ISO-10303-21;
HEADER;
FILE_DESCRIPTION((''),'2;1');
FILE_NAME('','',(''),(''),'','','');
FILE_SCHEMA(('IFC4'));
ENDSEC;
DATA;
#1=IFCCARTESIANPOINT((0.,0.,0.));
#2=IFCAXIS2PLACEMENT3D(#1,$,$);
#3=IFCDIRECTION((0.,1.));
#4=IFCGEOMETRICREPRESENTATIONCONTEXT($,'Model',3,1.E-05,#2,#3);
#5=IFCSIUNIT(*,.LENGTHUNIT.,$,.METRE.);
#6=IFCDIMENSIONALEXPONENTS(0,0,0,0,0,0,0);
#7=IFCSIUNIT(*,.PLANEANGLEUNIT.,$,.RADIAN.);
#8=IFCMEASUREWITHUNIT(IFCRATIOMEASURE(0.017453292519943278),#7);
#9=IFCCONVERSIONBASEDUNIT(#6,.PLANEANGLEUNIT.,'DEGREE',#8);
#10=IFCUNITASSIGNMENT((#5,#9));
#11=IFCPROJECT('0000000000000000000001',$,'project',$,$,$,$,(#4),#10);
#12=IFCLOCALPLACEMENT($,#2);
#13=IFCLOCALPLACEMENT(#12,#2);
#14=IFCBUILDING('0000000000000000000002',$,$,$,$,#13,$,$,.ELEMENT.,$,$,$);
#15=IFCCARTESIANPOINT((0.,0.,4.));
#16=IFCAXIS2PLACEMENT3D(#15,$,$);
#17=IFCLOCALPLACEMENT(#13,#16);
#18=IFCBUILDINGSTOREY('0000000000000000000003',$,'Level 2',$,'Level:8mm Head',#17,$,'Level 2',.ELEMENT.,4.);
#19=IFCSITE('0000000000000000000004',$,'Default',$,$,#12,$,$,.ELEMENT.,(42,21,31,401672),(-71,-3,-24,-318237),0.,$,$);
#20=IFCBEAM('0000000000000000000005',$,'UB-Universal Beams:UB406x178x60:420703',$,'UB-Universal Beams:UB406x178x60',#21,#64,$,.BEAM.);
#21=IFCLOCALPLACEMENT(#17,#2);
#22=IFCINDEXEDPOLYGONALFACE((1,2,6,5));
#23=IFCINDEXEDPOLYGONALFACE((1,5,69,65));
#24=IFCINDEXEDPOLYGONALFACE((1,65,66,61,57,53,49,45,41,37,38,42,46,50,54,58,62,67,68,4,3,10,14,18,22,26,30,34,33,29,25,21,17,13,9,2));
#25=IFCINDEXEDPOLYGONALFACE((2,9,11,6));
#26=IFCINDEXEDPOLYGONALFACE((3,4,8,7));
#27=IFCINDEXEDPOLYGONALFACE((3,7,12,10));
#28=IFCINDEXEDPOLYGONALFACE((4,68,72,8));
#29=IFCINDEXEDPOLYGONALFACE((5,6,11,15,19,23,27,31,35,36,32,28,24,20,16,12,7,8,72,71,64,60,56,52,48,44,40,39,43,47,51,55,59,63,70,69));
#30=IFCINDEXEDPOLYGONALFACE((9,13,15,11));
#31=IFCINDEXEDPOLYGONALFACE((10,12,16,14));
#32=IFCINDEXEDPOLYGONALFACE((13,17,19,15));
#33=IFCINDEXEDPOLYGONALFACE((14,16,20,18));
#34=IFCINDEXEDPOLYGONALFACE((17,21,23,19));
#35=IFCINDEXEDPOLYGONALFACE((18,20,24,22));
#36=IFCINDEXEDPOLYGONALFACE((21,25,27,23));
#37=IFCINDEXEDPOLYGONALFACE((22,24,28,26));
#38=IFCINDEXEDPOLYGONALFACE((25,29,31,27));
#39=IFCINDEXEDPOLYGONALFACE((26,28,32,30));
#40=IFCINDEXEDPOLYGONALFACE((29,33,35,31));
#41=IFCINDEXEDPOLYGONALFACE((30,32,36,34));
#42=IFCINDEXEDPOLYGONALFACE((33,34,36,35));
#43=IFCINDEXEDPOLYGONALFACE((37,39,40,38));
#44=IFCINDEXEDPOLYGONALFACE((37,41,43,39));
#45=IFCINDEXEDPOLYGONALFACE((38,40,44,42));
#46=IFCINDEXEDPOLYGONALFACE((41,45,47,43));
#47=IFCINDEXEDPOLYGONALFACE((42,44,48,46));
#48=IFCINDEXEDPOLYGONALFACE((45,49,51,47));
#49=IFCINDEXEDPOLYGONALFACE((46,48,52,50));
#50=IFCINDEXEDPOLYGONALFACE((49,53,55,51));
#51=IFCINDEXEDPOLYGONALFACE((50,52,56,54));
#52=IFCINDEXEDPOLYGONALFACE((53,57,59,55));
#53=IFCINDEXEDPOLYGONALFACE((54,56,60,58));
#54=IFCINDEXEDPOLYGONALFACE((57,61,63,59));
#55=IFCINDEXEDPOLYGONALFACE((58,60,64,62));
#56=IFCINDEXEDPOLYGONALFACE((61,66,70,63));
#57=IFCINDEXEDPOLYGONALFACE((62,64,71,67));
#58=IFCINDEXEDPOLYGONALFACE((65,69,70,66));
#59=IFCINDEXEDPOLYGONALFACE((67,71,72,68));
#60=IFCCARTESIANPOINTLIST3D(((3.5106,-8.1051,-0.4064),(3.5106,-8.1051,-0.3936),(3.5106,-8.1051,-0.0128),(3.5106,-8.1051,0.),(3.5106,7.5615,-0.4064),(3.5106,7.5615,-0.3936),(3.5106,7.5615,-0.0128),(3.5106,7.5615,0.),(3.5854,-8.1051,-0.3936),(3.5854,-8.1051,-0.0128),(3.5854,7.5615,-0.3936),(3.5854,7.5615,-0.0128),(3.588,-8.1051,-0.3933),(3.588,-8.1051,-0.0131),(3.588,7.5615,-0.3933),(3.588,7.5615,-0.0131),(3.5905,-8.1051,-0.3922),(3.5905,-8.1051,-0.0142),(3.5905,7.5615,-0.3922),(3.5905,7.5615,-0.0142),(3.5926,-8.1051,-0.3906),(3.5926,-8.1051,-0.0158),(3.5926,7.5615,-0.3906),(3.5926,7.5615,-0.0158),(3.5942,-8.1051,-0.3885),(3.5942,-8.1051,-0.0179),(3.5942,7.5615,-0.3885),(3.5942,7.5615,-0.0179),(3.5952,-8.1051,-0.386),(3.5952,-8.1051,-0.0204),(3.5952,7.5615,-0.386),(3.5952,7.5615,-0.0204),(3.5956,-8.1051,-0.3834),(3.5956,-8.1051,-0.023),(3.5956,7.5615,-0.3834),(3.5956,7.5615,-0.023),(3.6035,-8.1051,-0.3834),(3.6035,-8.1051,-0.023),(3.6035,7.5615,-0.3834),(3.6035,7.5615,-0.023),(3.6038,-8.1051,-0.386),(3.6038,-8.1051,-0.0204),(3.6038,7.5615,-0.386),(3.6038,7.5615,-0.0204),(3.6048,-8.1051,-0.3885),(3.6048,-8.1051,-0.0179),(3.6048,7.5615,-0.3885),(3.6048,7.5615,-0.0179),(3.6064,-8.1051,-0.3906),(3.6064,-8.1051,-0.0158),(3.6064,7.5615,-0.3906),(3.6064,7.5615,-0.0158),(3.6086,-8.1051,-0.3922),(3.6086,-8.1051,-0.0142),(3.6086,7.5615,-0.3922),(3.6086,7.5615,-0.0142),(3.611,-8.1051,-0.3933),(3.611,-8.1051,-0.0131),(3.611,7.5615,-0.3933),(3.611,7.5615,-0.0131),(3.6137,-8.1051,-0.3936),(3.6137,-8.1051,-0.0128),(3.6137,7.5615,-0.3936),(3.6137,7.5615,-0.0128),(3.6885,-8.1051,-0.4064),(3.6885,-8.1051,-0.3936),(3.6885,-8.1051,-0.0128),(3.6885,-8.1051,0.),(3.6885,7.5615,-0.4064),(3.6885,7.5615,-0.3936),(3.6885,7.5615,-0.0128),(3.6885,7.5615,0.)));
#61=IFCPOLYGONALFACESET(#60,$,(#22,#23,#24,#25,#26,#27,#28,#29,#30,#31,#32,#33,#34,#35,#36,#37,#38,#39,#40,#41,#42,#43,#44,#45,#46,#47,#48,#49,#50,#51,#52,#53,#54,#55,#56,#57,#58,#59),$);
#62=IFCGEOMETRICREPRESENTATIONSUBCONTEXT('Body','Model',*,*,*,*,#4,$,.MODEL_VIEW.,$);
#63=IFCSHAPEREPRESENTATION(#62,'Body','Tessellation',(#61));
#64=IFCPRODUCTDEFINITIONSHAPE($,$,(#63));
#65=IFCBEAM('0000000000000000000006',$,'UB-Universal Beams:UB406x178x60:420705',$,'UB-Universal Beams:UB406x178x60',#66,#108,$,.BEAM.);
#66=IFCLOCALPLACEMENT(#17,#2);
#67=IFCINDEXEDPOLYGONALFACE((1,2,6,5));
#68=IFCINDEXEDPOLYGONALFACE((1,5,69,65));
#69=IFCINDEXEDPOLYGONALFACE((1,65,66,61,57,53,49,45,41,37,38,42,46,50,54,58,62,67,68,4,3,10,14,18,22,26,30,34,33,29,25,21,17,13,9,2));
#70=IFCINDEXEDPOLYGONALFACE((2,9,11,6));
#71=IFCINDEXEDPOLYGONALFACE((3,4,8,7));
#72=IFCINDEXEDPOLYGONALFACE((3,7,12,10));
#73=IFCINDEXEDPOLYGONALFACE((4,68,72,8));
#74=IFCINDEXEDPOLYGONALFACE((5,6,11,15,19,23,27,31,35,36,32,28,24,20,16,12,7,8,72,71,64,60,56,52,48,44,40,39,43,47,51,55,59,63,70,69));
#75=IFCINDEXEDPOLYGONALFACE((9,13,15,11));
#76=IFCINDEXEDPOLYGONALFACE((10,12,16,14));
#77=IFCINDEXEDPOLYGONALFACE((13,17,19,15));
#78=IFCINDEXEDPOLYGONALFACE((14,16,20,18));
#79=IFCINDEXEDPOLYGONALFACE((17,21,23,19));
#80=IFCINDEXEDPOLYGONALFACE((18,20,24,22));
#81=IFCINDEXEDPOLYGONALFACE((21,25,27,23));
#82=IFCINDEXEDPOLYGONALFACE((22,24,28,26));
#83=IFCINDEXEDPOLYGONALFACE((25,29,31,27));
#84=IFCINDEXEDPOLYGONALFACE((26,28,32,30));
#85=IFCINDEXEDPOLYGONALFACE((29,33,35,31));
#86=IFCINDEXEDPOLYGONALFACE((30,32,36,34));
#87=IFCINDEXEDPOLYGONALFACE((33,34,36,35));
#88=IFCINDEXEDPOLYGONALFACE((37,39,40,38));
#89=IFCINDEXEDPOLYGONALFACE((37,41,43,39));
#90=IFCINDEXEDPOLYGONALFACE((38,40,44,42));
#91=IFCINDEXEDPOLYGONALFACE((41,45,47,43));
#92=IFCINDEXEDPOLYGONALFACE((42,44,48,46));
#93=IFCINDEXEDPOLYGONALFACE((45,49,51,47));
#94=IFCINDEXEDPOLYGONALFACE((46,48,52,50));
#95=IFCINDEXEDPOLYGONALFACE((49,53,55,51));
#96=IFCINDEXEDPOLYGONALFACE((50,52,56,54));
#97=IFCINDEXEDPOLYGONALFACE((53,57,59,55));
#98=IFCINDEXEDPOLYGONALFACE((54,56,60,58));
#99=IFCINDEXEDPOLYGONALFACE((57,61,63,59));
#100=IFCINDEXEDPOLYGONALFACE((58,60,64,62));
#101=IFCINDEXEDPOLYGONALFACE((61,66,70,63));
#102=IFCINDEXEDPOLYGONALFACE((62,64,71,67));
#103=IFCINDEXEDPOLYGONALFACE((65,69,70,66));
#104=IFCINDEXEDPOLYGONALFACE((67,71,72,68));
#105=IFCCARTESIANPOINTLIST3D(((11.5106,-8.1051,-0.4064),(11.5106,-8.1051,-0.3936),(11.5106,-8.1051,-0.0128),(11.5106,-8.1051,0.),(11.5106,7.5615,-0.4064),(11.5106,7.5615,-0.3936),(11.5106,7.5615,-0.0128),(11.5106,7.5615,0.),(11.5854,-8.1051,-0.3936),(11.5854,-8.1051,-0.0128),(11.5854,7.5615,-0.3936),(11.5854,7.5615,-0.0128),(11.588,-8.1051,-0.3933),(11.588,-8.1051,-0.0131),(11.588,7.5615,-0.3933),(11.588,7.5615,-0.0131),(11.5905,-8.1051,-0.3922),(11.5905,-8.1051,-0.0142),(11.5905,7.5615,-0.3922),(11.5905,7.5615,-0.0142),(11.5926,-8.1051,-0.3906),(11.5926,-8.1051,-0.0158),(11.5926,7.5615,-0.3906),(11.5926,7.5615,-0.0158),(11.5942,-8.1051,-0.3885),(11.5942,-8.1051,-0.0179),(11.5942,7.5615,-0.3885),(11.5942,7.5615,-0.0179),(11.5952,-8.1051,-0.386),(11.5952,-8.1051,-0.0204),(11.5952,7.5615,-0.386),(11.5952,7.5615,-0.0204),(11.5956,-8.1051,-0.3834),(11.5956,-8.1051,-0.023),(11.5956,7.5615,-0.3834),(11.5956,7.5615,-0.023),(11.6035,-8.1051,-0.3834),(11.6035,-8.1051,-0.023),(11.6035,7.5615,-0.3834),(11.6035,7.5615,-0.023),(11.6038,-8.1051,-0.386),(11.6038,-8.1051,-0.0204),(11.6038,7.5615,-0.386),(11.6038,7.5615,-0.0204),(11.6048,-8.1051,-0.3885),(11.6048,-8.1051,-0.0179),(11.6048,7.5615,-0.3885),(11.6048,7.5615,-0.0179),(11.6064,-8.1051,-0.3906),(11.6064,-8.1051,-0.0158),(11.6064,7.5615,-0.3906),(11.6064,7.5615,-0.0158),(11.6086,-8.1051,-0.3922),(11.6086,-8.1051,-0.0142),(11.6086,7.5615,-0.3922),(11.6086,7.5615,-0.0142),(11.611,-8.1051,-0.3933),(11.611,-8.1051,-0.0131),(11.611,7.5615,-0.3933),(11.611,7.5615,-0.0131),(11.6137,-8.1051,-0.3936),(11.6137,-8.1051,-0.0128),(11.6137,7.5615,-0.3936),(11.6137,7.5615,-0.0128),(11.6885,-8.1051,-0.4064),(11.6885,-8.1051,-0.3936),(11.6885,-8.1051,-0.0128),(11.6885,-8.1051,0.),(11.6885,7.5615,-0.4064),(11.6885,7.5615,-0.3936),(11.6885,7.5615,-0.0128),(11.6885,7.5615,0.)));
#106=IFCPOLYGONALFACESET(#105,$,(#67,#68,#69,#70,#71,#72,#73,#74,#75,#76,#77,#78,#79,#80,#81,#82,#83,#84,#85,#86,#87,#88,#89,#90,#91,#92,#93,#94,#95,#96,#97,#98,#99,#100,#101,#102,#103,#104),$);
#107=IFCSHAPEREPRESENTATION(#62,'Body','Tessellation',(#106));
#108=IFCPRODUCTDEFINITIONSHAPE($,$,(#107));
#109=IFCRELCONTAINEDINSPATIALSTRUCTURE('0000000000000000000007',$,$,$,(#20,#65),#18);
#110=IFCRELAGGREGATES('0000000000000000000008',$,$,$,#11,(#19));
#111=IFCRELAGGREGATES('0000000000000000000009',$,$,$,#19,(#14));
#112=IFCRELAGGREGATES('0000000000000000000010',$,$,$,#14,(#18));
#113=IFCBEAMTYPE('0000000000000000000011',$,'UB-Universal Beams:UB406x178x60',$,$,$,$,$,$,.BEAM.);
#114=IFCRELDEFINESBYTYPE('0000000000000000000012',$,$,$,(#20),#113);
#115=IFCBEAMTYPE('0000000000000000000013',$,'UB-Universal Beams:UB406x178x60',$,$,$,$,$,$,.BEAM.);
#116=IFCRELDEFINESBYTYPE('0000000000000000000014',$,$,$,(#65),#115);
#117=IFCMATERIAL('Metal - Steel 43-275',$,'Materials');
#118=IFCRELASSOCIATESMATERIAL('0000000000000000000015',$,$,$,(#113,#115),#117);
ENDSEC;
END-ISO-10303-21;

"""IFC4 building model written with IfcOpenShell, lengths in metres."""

from ifc_helpers import new_model, entity, si_unit, converted_unit, direction, frame, frame_2d, origin, place, context, subcontext, project, spatial, i_section, extrude, source, transform, mapped, material, material_profile, profile_set, type_object, type_shapes, element, save


model = new_model("IFC4")

# Units and contexts
model_context = context("Model", 3, precision=1e-05, world=origin(), true_north=direction((0.0, 1.0)))
body_context = subcontext(model_context, "Body", "Model", "MODEL_VIEW")
ifc_project = project(units=[si_unit("LENGTHUNIT", "METRE"), converted_unit("PLANEANGLEUNIT", "DEGREE", entity("IfcRatioMeasure", 0.017453292519943278), si_unit("PLANEANGLEUNIT", "RADIAN"), dimensions=[0, 0, 0, 0, 0, 0, 0])], contexts=[model_context])

# Site, building, storey
site_placement = place(None, origin())
site = spatial("IfcSite", under=ifc_project, at=site_placement, Name="Default", CompositionType="ELEMENT", RefLatitude=(42, 21, 31, 401672), RefLongitude=(-71, -3, -24, -318237), RefElevation=0.0)
building_placement = place(site_placement, origin())
building = spatial("IfcBuilding", under=site, at=building_placement, CompositionType="ELEMENT")
storey_placement = place(building_placement, frame((0.0, 0.0, 4.0)))
storey = spatial("IfcBuildingStorey", under=building, at=storey_placement, Name="Level 2", ObjectType="Level:8mm Head", LongName="Level 2", CompositionType="ELEMENT", Elevation=4.0)

# Shared definitions
ifc_material_1 = material(Name="Metal - Steel 43-275", Category="Materials")
ifc_material_profile_1 = material_profile(ifc_material_1, i_section(OverallWidth=0.1779, OverallDepth=0.4064, WebThickness=0.0079, FlangeThickness=0.0128, FilletRadius=0.0102, at=frame_2d((0.0, 0.0), x_axis=(0.0, 1.0))), Name="UB406x178x60")
ifc_profile_set_1 = profile_set([ifc_material_profile_1], Name="UB406x178x60")

# Beams
beam_type_1 = type_object("IfcBeamType", Name="UB-Universal Beams:UB406x178x60", PredefinedType="BEAM", material=ifc_profile_set_1)
shared_shape_1 = source(origin(), body_context, "Body", "SweptSolid", [
    extrude(i_section(OverallWidth=0.1779, OverallDepth=0.4064, WebThickness=0.0079, FlangeThickness=0.0128, FilletRadius=0.0102, at=frame_2d((0.0, 0.0), x_axis=(1.0, 0.0))), frame((3.5995, -8.1051, 3.7968), z_axis=(0.0, 1.0, 0.0), x_axis=(-1.0, 0.0, 0.0)), (0.0, 0.0, 1.0), 15.6666),
])
type_shapes(beam_type_1, [shared_shape_1])
beam_1_placement = place(storey_placement, frame((0.0, 0.0, -4.0)))
element("IfcBeam", 1, at=beam_1_placement, inside=storey, type_object=beam_type_1, Name="UB-Universal Beams:UB406x178x60:420703", ObjectType="UB-Universal Beams:UB406x178x60", PredefinedType="BEAM", context=body_context, shape_type="MappedRepresentation", body=[
    mapped(shared_shape_1, transform((0.0, 0.0, 0.0), scale=1.0)),
])
beam_type_2 = type_object("IfcBeamType", Name="UB-Universal Beams:UB406x178x60", PredefinedType="BEAM", material=ifc_profile_set_1)
shared_shape_2 = source(origin(), body_context, "Body", "SweptSolid", [
    extrude(i_section(OverallWidth=0.1779, OverallDepth=0.4064, WebThickness=0.0079, FlangeThickness=0.0128, FilletRadius=0.0102, at=frame_2d((0.0, 0.0), x_axis=(1.0, 0.0))), frame((11.5995, -8.1051, 3.7968), z_axis=(0.0, 1.0, 0.0), x_axis=(-1.0, 0.0, 0.0)), (0.0, 0.0, 1.0), 15.6666),
])
type_shapes(beam_type_2, [shared_shape_2])
beam_2_placement = place(storey_placement, frame((0.0, 0.0, -4.0)))
element("IfcBeam", 2, at=beam_2_placement, inside=storey, type_object=beam_type_2, Name="UB-Universal Beams:UB406x178x60:420705", ObjectType="UB-Universal Beams:UB406x178x60", PredefinedType="BEAM", context=body_context, shape_type="MappedRepresentation", body=[
    mapped(shared_shape_2, transform((0.0, 0.0, 0.0), scale=1.0)),
])

save(model, "model.ifc")
